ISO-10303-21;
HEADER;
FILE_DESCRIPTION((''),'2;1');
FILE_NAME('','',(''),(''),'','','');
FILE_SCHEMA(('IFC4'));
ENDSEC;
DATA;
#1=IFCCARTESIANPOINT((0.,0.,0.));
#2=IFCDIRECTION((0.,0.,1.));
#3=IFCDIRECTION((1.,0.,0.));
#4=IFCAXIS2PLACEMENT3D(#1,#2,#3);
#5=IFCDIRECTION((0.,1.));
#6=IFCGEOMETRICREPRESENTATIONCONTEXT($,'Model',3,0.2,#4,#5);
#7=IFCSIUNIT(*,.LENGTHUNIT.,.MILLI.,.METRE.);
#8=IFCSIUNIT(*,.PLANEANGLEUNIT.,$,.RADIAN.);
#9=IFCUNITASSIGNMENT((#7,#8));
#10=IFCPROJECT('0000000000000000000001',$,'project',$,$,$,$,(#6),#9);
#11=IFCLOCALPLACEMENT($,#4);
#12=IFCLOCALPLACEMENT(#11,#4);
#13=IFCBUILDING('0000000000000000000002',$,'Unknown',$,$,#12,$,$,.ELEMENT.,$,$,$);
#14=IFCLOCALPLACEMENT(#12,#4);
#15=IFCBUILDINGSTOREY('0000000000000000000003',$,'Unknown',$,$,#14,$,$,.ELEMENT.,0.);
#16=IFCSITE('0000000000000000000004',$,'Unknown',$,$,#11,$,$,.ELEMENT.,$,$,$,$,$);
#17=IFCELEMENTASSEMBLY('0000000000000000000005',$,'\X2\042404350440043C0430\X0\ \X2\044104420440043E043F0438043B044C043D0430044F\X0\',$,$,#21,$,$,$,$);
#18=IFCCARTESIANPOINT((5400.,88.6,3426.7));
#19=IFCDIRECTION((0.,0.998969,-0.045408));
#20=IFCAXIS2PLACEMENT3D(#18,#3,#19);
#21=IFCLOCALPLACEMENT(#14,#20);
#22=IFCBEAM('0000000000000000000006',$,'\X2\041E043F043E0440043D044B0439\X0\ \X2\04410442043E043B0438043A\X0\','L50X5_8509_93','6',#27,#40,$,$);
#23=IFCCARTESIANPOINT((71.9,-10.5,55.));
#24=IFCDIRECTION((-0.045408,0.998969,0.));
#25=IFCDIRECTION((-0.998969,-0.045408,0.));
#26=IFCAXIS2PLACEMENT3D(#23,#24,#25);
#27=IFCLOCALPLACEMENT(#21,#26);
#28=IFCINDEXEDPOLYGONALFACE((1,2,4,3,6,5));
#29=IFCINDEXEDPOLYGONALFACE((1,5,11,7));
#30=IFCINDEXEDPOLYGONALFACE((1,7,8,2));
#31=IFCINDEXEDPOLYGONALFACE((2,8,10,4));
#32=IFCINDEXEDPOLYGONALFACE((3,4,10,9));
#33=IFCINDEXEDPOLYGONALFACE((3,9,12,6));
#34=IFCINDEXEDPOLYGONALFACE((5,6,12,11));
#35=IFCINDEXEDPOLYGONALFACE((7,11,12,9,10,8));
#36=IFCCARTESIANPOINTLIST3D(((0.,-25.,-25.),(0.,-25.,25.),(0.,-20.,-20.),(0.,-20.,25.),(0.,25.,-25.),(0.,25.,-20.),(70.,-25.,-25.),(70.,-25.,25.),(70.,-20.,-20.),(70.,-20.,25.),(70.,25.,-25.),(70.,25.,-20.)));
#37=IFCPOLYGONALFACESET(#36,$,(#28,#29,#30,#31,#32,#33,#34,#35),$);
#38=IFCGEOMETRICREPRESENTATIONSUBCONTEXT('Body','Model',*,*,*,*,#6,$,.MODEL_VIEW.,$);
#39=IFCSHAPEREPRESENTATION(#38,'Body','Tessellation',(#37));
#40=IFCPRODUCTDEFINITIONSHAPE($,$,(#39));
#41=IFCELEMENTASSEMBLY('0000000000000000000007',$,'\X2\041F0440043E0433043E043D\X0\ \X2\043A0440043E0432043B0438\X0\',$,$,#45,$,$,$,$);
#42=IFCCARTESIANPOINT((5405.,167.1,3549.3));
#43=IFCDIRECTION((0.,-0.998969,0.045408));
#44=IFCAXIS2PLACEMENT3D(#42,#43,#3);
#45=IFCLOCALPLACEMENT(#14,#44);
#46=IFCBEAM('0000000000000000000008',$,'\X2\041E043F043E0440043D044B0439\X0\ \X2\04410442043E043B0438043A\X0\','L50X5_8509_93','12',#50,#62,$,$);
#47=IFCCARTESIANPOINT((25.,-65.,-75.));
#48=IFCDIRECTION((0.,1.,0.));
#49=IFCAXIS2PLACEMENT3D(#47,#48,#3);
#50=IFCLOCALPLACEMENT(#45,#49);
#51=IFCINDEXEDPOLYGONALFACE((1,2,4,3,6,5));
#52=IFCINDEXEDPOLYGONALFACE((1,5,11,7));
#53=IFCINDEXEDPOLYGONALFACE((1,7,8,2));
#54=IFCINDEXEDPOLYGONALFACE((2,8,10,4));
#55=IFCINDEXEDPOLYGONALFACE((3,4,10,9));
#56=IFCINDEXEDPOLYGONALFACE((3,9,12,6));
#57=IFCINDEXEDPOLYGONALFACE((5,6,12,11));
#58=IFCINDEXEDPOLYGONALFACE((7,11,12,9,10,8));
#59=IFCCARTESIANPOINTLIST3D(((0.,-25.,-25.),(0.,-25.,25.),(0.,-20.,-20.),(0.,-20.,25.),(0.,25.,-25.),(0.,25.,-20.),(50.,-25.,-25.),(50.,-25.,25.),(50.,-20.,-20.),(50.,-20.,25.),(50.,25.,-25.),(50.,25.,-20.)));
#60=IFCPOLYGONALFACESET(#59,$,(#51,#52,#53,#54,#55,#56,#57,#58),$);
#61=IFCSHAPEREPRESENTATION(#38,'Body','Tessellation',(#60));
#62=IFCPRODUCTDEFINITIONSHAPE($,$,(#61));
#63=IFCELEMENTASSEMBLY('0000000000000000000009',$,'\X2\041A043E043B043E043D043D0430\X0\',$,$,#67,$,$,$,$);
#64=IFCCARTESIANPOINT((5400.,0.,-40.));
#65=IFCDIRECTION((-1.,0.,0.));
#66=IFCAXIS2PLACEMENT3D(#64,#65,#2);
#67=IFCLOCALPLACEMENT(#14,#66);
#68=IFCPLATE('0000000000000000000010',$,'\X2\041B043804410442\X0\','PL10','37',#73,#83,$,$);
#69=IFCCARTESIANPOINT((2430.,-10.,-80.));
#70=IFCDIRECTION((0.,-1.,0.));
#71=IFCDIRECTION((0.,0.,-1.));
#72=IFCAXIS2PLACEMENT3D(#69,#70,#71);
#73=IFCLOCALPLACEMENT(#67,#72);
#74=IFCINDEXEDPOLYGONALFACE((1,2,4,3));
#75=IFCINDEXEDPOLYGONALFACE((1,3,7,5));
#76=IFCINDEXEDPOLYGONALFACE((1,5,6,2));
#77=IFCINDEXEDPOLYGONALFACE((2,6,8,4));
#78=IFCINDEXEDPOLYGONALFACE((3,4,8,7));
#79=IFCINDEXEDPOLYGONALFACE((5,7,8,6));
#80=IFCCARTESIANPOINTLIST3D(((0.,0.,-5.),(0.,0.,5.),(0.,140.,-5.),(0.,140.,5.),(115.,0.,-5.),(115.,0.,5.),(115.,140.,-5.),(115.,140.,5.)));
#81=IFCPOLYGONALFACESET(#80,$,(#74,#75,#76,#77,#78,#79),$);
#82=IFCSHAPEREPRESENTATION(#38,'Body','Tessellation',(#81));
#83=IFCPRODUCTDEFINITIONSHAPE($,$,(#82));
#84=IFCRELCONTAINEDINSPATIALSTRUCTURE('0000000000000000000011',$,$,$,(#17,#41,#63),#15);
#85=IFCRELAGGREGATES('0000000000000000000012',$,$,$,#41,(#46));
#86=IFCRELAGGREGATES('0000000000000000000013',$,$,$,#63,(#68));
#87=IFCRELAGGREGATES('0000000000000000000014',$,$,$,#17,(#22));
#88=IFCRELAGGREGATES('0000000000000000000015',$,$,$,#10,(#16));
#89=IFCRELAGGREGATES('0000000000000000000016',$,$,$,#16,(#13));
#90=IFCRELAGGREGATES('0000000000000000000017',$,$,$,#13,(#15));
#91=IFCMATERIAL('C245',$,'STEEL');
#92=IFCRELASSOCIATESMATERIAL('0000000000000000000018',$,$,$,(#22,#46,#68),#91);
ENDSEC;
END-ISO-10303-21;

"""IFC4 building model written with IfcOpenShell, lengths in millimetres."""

from ifc_helpers import new_model, si_unit, direction, frame, origin_with_axes, place, context, subcontext, project, spatial, line, indexed_curve, outline, extrude, material, element, aggregate, save


model = new_model("IFC4")

# Units and contexts
model_context = context("Model", 3, precision=0.2, world=origin_with_axes(), true_north=direction((0.0, 1.0)))
body_context = subcontext(model_context, "Body", "Model", "MODEL_VIEW")
ifc_project = project(units=[si_unit("LENGTHUNIT", "METRE", prefix="MILLI"), si_unit("PLANEANGLEUNIT", "RADIAN")], contexts=[model_context])

# Site, building, storey
site_placement = place(None, origin_with_axes())
site = spatial("IfcSite", under=ifc_project, at=site_placement, Name="Unknown", CompositionType="ELEMENT")
building_placement = place(site_placement, origin_with_axes())
building = spatial("IfcBuilding", under=site, at=building_placement, Name="Unknown", CompositionType="ELEMENT")
storey_placement = place(building_placement, origin_with_axes())
storey = spatial("IfcBuildingStorey", under=building, at=storey_placement, Name="Unknown", CompositionType="ELEMENT", Elevation=0.0)

# Shared definitions
ifc_material_1 = material(Name="C245", Category="STEEL")

# Element assemblies, beams
assembly_1_placement = place(storey_placement, frame((5400.0, 88.6, 3426.7), z_axis=(1.0, 0.0, 0.0), x_axis=(0.0, 0.998969, -0.045408)))
assembly_1 = element("IfcElementAssembly", 1, at=assembly_1_placement, inside=storey, Name="Ферма стропильная")
beam_1_placement = place(assembly_1_placement, frame((71.9, -10.5, 55.0), z_axis=(-0.045408, 0.998969, 0.0), x_axis=(-0.998969, -0.045408, 0.0)))
beam_1 = element("IfcBeam", 2, at=beam_1_placement, material=ifc_material_1, Name="Опорный столик", Description="L50X5_8509_93", ObjectType="6", context=body_context, shape_type="SolidModel", body=[
    extrude(outline(indexed_curve([(-25.0, -25.0), (25.0, -25.0), (25.0, -20.0), (-20.0, -20.0), (-20.0, 25.0), (-25.0, 25.0)], segments=[line(1, 2, 3, 4, 5, 6, 1)])), frame((0.0, 0.0, 0.0), z_axis=(-1.0, 0.0, 0.0), x_axis=(0.0, 0.0, 1.0)), (0.0, 0.0, -1.0), 70.0),
])
assembly_2_placement = place(storey_placement, frame((5405.0, 167.1, 3549.3), z_axis=(0.0, -0.998969, 0.045408), x_axis=(1.0, 0.0, 0.0)))
assembly_2 = element("IfcElementAssembly", 3, at=assembly_2_placement, inside=storey, Name="Прогон кровли")
beam_2_placement = place(assembly_2_placement, frame((25.0, -65.0, -75.0), z_axis=(0.0, 1.0, 0.0), x_axis=(1.0, 0.0, 0.0)))
beam_2 = element("IfcBeam", 4, at=beam_2_placement, material=ifc_material_1, Name="Опорный столик", Description="L50X5_8509_93", ObjectType="12", context=body_context, shape_type="SolidModel", body=[
    extrude(outline(indexed_curve([(-25.0, -25.0), (25.0, -25.0), (25.0, -20.0), (-20.0, -20.0), (-20.0, 25.0), (-25.0, 25.0)], segments=[line(1, 2, 3, 4, 5, 6, 1)])), frame((0.0, 0.0, 0.0), z_axis=(-1.0, 0.0, 0.0), x_axis=(0.0, 0.0, 1.0)), (0.0, 0.0, -1.0), 50.0),
])

# Element assembly, plate
assembly_3_placement = place(storey_placement, frame((5400.0, 0.0, -40.0), z_axis=(-1.0, 0.0, 0.0), x_axis=(0.0, 0.0, 1.0)))
assembly_3 = element("IfcElementAssembly", 5, at=assembly_3_placement, inside=storey, Name="Колонна")
plate_1_placement = place(assembly_3_placement, frame((2430.0, -10.0, -80.0), z_axis=(0.0, -1.0, 0.0), x_axis=(0.0, 0.0, -1.0)))
plate_1 = element("IfcPlate", 6, at=plate_1_placement, material=ifc_material_1, Name="Лист", Description="PL10", ObjectType="37", context=body_context, shape_type="SolidModel", body=[
    extrude(outline(indexed_curve([(0.0, 0.0), (115.0, 0.0), (115.0, 140.0), (0.0, 140.0)], segments=[line(1, 2, 3, 4, 1)])), frame((0.0, 0.0, 5.0), z_axis=(0.0, 0.0, 1.0), x_axis=(1.0, 0.0, 0.0)), (0.0, 0.0, -1.0), 10.0),
])

aggregate(assembly_2, [beam_2])

aggregate(assembly_3, [plate_1])
aggregate(assembly_1, [beam_1])

save(model, "model.ifc")
